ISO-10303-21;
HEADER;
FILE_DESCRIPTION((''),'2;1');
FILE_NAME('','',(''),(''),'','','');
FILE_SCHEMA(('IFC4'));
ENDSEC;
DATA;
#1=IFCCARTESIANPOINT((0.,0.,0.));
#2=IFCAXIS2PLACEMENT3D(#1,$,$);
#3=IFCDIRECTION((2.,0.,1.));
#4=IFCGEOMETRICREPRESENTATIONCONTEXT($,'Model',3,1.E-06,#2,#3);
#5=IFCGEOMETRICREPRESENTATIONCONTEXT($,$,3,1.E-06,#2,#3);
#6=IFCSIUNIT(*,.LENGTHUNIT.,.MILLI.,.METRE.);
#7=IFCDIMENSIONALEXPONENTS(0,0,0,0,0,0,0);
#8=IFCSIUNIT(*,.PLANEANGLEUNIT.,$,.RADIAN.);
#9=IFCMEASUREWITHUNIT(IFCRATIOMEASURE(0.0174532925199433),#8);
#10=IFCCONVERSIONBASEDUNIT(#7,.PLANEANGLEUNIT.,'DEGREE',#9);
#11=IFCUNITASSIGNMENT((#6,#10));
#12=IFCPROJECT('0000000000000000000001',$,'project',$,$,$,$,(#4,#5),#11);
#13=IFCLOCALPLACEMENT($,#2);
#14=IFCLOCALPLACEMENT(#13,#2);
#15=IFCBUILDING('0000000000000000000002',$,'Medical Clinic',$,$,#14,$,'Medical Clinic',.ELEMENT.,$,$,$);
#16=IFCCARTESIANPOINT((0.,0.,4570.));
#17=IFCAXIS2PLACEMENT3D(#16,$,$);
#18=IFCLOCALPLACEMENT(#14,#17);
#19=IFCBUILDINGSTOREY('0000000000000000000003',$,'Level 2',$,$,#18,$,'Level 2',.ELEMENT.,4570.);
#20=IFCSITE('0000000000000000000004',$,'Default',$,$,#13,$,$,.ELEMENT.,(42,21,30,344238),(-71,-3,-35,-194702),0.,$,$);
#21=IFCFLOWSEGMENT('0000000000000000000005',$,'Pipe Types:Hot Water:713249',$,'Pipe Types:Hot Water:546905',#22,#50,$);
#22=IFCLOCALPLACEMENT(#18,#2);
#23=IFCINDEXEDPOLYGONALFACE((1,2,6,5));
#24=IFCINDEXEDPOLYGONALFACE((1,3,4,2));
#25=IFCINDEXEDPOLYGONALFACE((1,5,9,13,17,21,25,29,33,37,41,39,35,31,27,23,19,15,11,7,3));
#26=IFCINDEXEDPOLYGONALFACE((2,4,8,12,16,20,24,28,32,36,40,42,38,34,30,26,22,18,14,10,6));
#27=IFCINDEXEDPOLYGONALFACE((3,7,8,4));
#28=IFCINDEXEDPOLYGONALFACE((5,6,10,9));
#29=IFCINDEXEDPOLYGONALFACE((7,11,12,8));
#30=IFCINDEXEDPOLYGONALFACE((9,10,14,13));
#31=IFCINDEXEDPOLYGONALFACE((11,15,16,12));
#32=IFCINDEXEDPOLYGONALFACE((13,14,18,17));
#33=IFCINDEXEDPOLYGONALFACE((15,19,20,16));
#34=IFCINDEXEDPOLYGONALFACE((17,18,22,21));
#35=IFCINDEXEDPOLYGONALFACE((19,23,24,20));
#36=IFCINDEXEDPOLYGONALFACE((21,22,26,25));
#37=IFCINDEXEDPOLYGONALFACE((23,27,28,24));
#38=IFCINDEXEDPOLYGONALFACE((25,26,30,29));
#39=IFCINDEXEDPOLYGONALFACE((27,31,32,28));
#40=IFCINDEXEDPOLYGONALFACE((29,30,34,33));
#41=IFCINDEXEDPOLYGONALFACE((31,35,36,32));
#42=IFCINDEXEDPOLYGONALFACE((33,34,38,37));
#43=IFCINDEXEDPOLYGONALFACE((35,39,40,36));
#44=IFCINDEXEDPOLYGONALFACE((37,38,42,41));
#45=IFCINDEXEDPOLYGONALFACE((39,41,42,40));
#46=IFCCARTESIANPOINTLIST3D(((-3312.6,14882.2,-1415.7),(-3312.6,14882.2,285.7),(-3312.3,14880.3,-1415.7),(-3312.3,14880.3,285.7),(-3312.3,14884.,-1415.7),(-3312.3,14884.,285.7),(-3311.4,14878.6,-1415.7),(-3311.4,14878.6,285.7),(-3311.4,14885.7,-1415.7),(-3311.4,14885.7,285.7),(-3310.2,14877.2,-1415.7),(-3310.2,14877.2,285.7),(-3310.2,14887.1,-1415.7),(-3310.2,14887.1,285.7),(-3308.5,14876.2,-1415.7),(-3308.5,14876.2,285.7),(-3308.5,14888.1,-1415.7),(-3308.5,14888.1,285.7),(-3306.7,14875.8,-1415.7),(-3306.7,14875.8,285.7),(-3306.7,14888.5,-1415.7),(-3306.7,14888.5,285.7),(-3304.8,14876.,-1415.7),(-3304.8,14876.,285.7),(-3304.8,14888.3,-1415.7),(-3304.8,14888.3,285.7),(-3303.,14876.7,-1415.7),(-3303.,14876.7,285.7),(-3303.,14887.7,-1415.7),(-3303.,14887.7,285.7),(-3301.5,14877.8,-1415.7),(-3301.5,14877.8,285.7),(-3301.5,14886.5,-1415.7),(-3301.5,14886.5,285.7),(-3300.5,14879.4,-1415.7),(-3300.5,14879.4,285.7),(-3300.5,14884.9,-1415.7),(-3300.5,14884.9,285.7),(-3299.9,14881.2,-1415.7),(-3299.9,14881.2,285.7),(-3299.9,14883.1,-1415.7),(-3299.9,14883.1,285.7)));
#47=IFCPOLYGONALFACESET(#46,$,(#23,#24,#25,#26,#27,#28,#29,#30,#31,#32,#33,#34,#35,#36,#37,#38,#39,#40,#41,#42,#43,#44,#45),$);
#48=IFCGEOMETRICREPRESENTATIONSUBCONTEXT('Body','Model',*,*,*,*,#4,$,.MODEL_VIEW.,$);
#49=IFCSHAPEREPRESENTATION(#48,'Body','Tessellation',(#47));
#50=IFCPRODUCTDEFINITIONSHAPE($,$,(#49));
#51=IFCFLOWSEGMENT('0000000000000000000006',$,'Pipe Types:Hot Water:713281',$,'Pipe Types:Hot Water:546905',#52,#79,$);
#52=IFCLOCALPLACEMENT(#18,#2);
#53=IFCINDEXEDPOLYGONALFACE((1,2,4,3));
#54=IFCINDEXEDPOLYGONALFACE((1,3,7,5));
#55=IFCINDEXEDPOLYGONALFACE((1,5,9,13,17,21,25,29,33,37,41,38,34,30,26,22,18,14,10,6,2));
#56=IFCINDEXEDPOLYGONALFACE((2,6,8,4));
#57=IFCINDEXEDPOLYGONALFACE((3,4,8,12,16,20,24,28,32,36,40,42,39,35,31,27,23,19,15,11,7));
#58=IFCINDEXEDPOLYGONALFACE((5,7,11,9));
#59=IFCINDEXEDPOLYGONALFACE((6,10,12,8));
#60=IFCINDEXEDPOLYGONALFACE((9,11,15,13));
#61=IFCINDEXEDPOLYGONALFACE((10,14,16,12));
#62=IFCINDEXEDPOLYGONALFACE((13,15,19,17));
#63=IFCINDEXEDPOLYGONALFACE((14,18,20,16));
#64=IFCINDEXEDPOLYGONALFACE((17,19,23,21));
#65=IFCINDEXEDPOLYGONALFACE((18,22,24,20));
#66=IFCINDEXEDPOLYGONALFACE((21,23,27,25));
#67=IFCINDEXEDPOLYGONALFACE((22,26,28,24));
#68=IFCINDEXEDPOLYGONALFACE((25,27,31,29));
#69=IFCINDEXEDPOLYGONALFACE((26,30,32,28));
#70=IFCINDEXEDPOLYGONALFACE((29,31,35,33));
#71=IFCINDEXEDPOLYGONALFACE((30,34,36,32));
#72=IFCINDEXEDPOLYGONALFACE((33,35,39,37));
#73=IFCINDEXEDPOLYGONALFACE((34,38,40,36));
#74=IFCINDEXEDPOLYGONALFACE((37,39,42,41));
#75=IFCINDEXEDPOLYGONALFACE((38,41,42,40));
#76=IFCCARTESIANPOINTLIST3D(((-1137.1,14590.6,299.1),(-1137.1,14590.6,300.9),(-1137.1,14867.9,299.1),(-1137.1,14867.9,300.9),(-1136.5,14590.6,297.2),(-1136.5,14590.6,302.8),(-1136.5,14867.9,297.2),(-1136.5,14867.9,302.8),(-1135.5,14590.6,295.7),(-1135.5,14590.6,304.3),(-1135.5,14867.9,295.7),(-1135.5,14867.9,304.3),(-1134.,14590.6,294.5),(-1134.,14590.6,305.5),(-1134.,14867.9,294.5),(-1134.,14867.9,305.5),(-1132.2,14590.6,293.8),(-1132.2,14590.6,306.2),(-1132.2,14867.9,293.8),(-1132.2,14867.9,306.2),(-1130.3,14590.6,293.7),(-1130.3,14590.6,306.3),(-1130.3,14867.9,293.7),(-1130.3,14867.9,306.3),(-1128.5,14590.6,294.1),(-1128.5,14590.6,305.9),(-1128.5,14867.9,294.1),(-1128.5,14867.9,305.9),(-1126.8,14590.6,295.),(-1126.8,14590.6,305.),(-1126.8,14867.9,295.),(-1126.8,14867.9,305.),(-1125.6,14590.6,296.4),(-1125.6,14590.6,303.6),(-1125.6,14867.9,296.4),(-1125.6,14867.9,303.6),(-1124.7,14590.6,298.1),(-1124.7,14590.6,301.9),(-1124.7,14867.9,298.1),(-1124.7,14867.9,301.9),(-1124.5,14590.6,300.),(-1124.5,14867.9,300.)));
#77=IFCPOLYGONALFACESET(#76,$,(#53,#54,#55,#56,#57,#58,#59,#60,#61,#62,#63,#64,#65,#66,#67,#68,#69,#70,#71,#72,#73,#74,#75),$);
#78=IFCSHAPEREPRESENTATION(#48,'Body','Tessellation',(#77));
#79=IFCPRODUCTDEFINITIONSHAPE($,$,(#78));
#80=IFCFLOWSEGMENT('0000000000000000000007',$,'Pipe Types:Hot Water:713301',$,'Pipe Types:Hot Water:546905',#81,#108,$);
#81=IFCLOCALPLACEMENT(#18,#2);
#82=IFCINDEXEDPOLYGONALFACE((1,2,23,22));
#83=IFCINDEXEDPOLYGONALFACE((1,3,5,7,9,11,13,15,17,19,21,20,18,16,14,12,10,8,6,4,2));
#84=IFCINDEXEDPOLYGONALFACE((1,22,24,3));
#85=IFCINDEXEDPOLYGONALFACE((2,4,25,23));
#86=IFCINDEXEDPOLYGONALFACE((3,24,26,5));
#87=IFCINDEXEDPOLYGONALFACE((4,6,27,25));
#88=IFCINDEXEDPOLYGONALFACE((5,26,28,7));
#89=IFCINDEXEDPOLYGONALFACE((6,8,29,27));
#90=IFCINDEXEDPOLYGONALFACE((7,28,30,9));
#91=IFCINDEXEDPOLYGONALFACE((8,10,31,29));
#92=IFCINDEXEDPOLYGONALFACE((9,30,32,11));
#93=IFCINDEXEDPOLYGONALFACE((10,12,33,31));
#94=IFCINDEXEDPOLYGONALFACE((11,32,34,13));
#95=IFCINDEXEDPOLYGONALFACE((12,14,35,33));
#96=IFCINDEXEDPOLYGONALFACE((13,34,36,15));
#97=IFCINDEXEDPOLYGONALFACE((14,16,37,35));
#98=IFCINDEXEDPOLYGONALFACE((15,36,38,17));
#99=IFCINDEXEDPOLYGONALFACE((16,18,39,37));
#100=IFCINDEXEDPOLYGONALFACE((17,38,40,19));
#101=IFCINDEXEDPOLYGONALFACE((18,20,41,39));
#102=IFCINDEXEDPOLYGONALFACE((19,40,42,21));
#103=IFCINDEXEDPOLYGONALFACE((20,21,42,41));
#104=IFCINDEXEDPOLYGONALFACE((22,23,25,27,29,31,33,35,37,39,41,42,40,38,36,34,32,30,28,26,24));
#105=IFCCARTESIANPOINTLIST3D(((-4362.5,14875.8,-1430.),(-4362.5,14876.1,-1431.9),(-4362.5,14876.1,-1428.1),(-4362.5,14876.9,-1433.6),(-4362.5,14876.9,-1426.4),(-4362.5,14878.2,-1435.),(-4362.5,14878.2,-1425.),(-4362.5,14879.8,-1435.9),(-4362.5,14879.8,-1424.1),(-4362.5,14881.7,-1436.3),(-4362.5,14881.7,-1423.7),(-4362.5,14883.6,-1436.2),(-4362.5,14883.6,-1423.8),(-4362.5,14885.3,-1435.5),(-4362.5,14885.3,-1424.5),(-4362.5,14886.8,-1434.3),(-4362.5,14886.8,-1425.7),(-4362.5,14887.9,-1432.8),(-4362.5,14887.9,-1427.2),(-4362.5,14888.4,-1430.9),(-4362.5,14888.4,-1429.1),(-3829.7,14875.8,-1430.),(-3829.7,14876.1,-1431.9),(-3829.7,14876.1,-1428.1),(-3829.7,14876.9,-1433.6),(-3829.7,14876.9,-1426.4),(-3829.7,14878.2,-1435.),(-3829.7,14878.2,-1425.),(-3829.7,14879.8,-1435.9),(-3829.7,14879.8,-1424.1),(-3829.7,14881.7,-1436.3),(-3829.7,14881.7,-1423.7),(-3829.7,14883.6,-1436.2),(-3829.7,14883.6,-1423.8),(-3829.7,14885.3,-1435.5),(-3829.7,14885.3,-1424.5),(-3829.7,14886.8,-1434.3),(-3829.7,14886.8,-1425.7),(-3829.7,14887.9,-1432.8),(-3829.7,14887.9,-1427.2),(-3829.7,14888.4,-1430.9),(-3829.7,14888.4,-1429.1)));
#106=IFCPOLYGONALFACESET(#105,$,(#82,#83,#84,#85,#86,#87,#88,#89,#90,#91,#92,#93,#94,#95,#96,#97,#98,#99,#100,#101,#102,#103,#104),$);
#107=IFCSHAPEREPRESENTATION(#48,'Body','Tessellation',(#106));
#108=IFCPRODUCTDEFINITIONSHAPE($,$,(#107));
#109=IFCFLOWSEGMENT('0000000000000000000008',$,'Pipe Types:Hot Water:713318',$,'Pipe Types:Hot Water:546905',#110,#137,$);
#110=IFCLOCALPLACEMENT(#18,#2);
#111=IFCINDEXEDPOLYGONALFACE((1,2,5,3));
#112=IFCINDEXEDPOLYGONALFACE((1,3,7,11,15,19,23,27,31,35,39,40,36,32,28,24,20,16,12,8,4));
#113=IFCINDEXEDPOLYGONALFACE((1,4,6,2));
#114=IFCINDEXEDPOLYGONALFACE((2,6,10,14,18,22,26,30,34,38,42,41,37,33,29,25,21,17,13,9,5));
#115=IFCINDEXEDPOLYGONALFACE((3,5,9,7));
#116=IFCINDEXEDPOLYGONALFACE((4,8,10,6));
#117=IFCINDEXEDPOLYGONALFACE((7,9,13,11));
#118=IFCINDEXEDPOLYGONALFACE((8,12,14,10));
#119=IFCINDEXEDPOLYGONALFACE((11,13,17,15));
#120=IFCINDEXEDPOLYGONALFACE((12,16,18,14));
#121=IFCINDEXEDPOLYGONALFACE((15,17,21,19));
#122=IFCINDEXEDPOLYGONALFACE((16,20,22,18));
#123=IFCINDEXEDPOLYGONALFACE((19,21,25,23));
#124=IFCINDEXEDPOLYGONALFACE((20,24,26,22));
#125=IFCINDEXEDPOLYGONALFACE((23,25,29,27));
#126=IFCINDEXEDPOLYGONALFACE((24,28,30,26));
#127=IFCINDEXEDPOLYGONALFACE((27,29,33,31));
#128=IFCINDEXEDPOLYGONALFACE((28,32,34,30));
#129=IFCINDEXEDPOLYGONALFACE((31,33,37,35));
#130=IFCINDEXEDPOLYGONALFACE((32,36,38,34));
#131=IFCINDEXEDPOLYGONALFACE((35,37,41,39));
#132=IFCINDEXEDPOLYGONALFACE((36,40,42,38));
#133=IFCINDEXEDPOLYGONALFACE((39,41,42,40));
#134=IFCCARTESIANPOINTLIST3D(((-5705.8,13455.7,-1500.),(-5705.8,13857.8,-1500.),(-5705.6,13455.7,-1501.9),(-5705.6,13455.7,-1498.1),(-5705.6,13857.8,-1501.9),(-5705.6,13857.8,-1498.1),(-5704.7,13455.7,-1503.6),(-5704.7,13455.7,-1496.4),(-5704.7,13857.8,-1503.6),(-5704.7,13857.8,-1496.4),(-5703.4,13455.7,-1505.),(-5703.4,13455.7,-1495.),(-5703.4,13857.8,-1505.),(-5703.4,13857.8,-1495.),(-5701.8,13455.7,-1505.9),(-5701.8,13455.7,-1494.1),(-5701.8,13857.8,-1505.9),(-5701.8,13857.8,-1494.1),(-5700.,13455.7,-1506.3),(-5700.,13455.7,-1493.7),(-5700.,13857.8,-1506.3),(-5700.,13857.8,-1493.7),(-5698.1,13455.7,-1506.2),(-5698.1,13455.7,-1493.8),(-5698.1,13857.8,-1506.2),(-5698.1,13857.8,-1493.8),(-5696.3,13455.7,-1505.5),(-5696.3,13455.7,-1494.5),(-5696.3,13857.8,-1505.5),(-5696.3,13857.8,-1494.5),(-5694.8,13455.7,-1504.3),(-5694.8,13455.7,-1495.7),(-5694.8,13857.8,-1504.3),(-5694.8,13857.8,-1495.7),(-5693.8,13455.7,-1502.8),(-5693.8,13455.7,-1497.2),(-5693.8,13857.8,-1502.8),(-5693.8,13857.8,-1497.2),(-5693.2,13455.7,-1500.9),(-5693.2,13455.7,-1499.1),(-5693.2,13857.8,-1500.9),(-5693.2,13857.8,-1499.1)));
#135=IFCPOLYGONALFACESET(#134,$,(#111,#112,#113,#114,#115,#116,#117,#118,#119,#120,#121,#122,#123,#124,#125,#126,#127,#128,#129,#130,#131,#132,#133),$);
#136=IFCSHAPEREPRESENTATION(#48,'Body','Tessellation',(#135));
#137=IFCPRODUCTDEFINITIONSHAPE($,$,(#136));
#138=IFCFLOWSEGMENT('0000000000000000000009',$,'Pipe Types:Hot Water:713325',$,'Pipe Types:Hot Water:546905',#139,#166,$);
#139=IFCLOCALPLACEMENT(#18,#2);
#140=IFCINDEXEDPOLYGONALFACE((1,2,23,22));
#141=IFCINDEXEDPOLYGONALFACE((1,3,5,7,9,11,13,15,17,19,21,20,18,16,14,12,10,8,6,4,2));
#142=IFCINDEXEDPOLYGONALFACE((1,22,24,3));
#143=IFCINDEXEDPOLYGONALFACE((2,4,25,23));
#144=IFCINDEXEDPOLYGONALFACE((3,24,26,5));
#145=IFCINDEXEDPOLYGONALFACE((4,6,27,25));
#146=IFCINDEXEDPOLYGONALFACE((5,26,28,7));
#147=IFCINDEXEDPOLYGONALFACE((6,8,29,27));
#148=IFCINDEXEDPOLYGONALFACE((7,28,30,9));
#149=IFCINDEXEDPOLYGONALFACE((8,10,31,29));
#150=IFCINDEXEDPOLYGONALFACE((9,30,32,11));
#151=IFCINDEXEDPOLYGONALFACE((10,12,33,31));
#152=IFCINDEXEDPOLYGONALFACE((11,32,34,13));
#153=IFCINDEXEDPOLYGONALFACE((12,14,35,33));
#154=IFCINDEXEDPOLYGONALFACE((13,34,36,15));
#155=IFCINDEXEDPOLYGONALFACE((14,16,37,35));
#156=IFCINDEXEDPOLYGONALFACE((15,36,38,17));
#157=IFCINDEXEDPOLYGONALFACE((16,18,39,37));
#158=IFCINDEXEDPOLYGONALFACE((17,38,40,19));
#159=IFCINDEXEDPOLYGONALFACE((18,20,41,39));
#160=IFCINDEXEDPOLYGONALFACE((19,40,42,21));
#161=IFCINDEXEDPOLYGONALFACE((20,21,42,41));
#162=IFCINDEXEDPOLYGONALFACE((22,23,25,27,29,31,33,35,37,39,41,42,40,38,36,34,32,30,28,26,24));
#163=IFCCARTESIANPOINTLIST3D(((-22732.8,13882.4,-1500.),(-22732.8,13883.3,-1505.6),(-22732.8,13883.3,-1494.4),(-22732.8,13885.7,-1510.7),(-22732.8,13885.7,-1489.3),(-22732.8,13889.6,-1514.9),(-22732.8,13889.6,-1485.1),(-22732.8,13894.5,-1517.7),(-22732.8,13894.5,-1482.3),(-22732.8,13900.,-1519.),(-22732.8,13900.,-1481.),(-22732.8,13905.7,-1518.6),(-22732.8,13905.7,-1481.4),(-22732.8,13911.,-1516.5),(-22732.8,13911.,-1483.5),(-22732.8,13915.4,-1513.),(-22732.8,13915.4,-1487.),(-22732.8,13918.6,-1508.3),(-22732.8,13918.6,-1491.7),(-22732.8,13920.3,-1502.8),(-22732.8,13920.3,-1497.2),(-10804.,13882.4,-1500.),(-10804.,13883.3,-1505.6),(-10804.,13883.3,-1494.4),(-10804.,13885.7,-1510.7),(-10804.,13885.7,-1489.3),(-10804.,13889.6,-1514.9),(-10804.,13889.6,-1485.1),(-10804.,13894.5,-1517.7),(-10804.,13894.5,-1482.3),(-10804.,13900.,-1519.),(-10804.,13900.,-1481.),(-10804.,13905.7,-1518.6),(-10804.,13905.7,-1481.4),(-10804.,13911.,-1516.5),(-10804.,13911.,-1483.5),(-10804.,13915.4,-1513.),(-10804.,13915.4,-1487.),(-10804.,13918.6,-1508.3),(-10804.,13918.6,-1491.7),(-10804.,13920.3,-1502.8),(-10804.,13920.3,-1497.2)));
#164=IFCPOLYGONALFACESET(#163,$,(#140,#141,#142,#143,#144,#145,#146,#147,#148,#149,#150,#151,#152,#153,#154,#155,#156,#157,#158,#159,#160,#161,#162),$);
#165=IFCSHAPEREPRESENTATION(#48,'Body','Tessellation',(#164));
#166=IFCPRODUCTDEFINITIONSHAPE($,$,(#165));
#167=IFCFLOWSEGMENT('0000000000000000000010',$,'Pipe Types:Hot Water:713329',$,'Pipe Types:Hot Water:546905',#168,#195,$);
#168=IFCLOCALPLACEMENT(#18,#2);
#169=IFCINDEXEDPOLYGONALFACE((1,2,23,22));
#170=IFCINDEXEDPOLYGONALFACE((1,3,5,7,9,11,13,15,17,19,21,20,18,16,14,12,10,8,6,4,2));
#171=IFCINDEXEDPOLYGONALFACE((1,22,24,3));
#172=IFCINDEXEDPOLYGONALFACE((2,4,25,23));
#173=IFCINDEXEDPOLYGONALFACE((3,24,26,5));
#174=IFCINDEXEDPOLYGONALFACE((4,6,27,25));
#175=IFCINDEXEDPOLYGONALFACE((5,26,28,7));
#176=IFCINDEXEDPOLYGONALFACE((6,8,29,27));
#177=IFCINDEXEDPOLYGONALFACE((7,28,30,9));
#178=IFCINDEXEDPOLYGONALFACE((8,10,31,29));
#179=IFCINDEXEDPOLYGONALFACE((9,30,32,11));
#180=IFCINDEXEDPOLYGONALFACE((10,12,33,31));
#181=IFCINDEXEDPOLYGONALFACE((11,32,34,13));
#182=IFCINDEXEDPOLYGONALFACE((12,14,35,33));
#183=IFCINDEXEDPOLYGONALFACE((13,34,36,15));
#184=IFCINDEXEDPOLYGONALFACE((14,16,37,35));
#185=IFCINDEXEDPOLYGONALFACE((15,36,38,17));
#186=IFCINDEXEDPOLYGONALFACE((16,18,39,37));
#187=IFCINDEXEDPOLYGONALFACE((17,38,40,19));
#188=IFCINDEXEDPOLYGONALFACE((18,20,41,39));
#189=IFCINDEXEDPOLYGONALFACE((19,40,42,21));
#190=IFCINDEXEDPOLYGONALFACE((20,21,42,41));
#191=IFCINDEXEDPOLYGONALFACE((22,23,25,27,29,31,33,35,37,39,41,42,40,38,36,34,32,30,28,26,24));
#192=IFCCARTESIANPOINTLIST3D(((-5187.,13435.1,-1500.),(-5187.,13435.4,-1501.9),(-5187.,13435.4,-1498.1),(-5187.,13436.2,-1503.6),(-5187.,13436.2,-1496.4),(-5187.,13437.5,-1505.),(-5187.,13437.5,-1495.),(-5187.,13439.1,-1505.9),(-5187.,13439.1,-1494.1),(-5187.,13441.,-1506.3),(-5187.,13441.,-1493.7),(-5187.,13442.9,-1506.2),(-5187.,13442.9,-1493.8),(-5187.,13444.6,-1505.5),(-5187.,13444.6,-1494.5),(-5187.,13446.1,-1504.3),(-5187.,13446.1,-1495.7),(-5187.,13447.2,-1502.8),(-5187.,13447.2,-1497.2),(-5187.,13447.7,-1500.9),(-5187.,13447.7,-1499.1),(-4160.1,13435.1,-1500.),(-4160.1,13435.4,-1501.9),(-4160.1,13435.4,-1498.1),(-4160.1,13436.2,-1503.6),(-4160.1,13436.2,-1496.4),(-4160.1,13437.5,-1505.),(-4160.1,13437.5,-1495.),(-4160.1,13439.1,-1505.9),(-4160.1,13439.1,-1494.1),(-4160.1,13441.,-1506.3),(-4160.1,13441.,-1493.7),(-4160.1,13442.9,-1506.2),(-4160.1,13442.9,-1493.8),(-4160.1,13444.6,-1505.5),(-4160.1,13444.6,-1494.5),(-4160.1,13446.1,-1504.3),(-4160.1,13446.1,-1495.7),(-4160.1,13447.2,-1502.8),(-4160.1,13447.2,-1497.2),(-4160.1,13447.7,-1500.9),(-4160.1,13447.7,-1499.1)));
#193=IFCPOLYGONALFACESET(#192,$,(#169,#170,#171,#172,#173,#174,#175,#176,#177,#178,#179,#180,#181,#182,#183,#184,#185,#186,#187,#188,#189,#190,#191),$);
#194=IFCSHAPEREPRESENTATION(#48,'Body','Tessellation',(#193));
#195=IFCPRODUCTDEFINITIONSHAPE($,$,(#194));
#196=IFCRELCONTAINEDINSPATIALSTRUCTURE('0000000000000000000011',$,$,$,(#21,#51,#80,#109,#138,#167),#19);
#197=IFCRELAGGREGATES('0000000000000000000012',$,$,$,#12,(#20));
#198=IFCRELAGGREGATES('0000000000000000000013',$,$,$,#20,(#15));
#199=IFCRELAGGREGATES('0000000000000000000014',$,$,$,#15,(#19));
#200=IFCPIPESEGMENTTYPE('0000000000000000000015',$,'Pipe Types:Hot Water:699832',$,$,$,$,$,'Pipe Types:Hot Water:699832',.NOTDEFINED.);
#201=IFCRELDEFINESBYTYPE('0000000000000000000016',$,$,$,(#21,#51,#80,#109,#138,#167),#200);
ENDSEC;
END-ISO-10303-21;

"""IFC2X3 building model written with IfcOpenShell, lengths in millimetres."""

from ifc_helpers import new_model, entity, si_unit, converted_unit, direction, frame, frame_2d, origin, origin_2d_with_axis, place, context, subcontext, project, spatial, circle, extrude, type_object, element, save


model = new_model("IFC2X3")

# Units and contexts
model_context = context("Model", 3, precision=1e-06, world=origin(), true_north=direction((2.0, 0.0, 1.0)))
context_of_model = context(None, 3, precision=1e-06, world=origin(), true_north=direction((2.0, 0.0, 1.0)))
body_context = subcontext(model_context, "Body", "Model", "MODEL_VIEW")
ifc_project = project(units=[si_unit("LENGTHUNIT", "METRE", prefix="MILLI"), converted_unit("PLANEANGLEUNIT", "DEGREE", entity("IfcRatioMeasure", 0.0174532925199433), si_unit("PLANEANGLEUNIT", "RADIAN"), dimensions=[0, 0, 0, 0, 0, 0, 0])], contexts=[model_context, context_of_model])

# Site, building, storey
site_placement = place(None, origin())
site = spatial("IfcSite", under=ifc_project, at=site_placement, Name="Default", CompositionType="ELEMENT", RefLatitude=(42, 21, 30, 344238), RefLongitude=(-71, -3, -35, -194702), RefElevation=0.0)
building_placement = place(site_placement, origin())
building = spatial("IfcBuilding", under=site, at=building_placement, Name="Medical Clinic", LongName="Medical Clinic", CompositionType="ELEMENT")
storey_placement = place(building_placement, frame((0.0, 0.0, 4570.0)))
storey = spatial("IfcBuildingStorey", under=building, at=storey_placement, Name="Level 2", LongName="Level 2", CompositionType="ELEMENT", Elevation=4570.0)

# Flow segments
pipe_segment_type_1 = type_object("IfcPipeSegmentType", Name="Pipe Types:Hot Water:699832", ElementType="Pipe Types:Hot Water:699832", PredefinedType="NOTDEFINED")
flow_segment_1_placement = place(storey_placement, origin())
element("IfcFlowSegment", 1, at=flow_segment_1_placement, inside=storey, type_object=pipe_segment_type_1, Name="Pipe Types:Hot Water:713249", ObjectType="Pipe Types:Hot Water:546905", context=body_context, shape_type="SweptSolid", body=[
    extrude(circle(Radius=6.3, at=frame_2d((0.0, 0.0), x_axis=(1.0, 0.0))), frame((-3306.2, 14882.2, -1415.7), z_axis=(0.0, 0.0, 1.0), x_axis=(-1.0, 0.0, 0.0)), (0.0, 0.0, 1.0), 1701.4),
])
flow_segment_2_placement = place(storey_placement, origin())
element("IfcFlowSegment", 2, at=flow_segment_2_placement, inside=storey, type_object=pipe_segment_type_1, Name="Pipe Types:Hot Water:713281", ObjectType="Pipe Types:Hot Water:546905", context=body_context, shape_type="SweptSolid", body=[
    extrude(circle(Radius=6.3, at=origin_2d_with_axis()), frame((-1130.8, 14590.6, 300.0), z_axis=(0.0, 1.0, 0.0), x_axis=(1.0, 0.0, 0.0)), (0.0, 0.0, 1.0), 277.2),
])
flow_segment_3_placement = place(storey_placement, origin())
element("IfcFlowSegment", 3, at=flow_segment_3_placement, inside=storey, type_object=pipe_segment_type_1, Name="Pipe Types:Hot Water:713301", ObjectType="Pipe Types:Hot Water:546905", context=body_context, shape_type="SweptSolid", body=[
    extrude(circle(Radius=6.3, at=origin_2d_with_axis()), frame((-4362.5, 14882.2, -1430.0), z_axis=(1.0, 0.0, 0.0), x_axis=(0.0, -1.0, 0.0)), (0.0, 0.0, 1.0), 532.9),
])
flow_segment_4_placement = place(storey_placement, origin())
element("IfcFlowSegment", 4, at=flow_segment_4_placement, inside=storey, type_object=pipe_segment_type_1, Name="Pipe Types:Hot Water:713318", ObjectType="Pipe Types:Hot Water:546905", context=body_context, shape_type="SweptSolid", body=[
    extrude(circle(Radius=6.3, at=origin_2d_with_axis()), frame((-5699.5, 13455.7, -1500.0), z_axis=(0.0, 1.0, 0.0), x_axis=(-1.0, 0.0, 0.0)), (0.0, 0.0, 1.0), 402.1),
])
flow_segment_5_placement = place(storey_placement, origin())
element("IfcFlowSegment", 5, at=flow_segment_5_placement, inside=storey, type_object=pipe_segment_type_1, Name="Pipe Types:Hot Water:713325", ObjectType="Pipe Types:Hot Water:546905", context=body_context, shape_type="SweptSolid", body=[
    extrude(circle(Radius=19.1, at=origin_2d_with_axis()), frame((-22732.8, 13901.5, -1500.0), z_axis=(1.0, 0.0, 0.0), x_axis=(0.0, -1.0, 0.0)), (0.0, 0.0, 1.0), 11928.8),
])
flow_segment_6_placement = place(storey_placement, origin())
element("IfcFlowSegment", 6, at=flow_segment_6_placement, inside=storey, type_object=pipe_segment_type_1, Name="Pipe Types:Hot Water:713329", ObjectType="Pipe Types:Hot Water:546905", context=body_context, shape_type="SweptSolid", body=[
    extrude(circle(Radius=6.3, at=origin_2d_with_axis()), frame((-5187.0, 13441.5, -1500.0), z_axis=(1.0, 0.0, 0.0), x_axis=(0.0, -1.0, 0.0)), (0.0, 0.0, 1.0), 1026.9),
])

save(model, "model.ifc")
